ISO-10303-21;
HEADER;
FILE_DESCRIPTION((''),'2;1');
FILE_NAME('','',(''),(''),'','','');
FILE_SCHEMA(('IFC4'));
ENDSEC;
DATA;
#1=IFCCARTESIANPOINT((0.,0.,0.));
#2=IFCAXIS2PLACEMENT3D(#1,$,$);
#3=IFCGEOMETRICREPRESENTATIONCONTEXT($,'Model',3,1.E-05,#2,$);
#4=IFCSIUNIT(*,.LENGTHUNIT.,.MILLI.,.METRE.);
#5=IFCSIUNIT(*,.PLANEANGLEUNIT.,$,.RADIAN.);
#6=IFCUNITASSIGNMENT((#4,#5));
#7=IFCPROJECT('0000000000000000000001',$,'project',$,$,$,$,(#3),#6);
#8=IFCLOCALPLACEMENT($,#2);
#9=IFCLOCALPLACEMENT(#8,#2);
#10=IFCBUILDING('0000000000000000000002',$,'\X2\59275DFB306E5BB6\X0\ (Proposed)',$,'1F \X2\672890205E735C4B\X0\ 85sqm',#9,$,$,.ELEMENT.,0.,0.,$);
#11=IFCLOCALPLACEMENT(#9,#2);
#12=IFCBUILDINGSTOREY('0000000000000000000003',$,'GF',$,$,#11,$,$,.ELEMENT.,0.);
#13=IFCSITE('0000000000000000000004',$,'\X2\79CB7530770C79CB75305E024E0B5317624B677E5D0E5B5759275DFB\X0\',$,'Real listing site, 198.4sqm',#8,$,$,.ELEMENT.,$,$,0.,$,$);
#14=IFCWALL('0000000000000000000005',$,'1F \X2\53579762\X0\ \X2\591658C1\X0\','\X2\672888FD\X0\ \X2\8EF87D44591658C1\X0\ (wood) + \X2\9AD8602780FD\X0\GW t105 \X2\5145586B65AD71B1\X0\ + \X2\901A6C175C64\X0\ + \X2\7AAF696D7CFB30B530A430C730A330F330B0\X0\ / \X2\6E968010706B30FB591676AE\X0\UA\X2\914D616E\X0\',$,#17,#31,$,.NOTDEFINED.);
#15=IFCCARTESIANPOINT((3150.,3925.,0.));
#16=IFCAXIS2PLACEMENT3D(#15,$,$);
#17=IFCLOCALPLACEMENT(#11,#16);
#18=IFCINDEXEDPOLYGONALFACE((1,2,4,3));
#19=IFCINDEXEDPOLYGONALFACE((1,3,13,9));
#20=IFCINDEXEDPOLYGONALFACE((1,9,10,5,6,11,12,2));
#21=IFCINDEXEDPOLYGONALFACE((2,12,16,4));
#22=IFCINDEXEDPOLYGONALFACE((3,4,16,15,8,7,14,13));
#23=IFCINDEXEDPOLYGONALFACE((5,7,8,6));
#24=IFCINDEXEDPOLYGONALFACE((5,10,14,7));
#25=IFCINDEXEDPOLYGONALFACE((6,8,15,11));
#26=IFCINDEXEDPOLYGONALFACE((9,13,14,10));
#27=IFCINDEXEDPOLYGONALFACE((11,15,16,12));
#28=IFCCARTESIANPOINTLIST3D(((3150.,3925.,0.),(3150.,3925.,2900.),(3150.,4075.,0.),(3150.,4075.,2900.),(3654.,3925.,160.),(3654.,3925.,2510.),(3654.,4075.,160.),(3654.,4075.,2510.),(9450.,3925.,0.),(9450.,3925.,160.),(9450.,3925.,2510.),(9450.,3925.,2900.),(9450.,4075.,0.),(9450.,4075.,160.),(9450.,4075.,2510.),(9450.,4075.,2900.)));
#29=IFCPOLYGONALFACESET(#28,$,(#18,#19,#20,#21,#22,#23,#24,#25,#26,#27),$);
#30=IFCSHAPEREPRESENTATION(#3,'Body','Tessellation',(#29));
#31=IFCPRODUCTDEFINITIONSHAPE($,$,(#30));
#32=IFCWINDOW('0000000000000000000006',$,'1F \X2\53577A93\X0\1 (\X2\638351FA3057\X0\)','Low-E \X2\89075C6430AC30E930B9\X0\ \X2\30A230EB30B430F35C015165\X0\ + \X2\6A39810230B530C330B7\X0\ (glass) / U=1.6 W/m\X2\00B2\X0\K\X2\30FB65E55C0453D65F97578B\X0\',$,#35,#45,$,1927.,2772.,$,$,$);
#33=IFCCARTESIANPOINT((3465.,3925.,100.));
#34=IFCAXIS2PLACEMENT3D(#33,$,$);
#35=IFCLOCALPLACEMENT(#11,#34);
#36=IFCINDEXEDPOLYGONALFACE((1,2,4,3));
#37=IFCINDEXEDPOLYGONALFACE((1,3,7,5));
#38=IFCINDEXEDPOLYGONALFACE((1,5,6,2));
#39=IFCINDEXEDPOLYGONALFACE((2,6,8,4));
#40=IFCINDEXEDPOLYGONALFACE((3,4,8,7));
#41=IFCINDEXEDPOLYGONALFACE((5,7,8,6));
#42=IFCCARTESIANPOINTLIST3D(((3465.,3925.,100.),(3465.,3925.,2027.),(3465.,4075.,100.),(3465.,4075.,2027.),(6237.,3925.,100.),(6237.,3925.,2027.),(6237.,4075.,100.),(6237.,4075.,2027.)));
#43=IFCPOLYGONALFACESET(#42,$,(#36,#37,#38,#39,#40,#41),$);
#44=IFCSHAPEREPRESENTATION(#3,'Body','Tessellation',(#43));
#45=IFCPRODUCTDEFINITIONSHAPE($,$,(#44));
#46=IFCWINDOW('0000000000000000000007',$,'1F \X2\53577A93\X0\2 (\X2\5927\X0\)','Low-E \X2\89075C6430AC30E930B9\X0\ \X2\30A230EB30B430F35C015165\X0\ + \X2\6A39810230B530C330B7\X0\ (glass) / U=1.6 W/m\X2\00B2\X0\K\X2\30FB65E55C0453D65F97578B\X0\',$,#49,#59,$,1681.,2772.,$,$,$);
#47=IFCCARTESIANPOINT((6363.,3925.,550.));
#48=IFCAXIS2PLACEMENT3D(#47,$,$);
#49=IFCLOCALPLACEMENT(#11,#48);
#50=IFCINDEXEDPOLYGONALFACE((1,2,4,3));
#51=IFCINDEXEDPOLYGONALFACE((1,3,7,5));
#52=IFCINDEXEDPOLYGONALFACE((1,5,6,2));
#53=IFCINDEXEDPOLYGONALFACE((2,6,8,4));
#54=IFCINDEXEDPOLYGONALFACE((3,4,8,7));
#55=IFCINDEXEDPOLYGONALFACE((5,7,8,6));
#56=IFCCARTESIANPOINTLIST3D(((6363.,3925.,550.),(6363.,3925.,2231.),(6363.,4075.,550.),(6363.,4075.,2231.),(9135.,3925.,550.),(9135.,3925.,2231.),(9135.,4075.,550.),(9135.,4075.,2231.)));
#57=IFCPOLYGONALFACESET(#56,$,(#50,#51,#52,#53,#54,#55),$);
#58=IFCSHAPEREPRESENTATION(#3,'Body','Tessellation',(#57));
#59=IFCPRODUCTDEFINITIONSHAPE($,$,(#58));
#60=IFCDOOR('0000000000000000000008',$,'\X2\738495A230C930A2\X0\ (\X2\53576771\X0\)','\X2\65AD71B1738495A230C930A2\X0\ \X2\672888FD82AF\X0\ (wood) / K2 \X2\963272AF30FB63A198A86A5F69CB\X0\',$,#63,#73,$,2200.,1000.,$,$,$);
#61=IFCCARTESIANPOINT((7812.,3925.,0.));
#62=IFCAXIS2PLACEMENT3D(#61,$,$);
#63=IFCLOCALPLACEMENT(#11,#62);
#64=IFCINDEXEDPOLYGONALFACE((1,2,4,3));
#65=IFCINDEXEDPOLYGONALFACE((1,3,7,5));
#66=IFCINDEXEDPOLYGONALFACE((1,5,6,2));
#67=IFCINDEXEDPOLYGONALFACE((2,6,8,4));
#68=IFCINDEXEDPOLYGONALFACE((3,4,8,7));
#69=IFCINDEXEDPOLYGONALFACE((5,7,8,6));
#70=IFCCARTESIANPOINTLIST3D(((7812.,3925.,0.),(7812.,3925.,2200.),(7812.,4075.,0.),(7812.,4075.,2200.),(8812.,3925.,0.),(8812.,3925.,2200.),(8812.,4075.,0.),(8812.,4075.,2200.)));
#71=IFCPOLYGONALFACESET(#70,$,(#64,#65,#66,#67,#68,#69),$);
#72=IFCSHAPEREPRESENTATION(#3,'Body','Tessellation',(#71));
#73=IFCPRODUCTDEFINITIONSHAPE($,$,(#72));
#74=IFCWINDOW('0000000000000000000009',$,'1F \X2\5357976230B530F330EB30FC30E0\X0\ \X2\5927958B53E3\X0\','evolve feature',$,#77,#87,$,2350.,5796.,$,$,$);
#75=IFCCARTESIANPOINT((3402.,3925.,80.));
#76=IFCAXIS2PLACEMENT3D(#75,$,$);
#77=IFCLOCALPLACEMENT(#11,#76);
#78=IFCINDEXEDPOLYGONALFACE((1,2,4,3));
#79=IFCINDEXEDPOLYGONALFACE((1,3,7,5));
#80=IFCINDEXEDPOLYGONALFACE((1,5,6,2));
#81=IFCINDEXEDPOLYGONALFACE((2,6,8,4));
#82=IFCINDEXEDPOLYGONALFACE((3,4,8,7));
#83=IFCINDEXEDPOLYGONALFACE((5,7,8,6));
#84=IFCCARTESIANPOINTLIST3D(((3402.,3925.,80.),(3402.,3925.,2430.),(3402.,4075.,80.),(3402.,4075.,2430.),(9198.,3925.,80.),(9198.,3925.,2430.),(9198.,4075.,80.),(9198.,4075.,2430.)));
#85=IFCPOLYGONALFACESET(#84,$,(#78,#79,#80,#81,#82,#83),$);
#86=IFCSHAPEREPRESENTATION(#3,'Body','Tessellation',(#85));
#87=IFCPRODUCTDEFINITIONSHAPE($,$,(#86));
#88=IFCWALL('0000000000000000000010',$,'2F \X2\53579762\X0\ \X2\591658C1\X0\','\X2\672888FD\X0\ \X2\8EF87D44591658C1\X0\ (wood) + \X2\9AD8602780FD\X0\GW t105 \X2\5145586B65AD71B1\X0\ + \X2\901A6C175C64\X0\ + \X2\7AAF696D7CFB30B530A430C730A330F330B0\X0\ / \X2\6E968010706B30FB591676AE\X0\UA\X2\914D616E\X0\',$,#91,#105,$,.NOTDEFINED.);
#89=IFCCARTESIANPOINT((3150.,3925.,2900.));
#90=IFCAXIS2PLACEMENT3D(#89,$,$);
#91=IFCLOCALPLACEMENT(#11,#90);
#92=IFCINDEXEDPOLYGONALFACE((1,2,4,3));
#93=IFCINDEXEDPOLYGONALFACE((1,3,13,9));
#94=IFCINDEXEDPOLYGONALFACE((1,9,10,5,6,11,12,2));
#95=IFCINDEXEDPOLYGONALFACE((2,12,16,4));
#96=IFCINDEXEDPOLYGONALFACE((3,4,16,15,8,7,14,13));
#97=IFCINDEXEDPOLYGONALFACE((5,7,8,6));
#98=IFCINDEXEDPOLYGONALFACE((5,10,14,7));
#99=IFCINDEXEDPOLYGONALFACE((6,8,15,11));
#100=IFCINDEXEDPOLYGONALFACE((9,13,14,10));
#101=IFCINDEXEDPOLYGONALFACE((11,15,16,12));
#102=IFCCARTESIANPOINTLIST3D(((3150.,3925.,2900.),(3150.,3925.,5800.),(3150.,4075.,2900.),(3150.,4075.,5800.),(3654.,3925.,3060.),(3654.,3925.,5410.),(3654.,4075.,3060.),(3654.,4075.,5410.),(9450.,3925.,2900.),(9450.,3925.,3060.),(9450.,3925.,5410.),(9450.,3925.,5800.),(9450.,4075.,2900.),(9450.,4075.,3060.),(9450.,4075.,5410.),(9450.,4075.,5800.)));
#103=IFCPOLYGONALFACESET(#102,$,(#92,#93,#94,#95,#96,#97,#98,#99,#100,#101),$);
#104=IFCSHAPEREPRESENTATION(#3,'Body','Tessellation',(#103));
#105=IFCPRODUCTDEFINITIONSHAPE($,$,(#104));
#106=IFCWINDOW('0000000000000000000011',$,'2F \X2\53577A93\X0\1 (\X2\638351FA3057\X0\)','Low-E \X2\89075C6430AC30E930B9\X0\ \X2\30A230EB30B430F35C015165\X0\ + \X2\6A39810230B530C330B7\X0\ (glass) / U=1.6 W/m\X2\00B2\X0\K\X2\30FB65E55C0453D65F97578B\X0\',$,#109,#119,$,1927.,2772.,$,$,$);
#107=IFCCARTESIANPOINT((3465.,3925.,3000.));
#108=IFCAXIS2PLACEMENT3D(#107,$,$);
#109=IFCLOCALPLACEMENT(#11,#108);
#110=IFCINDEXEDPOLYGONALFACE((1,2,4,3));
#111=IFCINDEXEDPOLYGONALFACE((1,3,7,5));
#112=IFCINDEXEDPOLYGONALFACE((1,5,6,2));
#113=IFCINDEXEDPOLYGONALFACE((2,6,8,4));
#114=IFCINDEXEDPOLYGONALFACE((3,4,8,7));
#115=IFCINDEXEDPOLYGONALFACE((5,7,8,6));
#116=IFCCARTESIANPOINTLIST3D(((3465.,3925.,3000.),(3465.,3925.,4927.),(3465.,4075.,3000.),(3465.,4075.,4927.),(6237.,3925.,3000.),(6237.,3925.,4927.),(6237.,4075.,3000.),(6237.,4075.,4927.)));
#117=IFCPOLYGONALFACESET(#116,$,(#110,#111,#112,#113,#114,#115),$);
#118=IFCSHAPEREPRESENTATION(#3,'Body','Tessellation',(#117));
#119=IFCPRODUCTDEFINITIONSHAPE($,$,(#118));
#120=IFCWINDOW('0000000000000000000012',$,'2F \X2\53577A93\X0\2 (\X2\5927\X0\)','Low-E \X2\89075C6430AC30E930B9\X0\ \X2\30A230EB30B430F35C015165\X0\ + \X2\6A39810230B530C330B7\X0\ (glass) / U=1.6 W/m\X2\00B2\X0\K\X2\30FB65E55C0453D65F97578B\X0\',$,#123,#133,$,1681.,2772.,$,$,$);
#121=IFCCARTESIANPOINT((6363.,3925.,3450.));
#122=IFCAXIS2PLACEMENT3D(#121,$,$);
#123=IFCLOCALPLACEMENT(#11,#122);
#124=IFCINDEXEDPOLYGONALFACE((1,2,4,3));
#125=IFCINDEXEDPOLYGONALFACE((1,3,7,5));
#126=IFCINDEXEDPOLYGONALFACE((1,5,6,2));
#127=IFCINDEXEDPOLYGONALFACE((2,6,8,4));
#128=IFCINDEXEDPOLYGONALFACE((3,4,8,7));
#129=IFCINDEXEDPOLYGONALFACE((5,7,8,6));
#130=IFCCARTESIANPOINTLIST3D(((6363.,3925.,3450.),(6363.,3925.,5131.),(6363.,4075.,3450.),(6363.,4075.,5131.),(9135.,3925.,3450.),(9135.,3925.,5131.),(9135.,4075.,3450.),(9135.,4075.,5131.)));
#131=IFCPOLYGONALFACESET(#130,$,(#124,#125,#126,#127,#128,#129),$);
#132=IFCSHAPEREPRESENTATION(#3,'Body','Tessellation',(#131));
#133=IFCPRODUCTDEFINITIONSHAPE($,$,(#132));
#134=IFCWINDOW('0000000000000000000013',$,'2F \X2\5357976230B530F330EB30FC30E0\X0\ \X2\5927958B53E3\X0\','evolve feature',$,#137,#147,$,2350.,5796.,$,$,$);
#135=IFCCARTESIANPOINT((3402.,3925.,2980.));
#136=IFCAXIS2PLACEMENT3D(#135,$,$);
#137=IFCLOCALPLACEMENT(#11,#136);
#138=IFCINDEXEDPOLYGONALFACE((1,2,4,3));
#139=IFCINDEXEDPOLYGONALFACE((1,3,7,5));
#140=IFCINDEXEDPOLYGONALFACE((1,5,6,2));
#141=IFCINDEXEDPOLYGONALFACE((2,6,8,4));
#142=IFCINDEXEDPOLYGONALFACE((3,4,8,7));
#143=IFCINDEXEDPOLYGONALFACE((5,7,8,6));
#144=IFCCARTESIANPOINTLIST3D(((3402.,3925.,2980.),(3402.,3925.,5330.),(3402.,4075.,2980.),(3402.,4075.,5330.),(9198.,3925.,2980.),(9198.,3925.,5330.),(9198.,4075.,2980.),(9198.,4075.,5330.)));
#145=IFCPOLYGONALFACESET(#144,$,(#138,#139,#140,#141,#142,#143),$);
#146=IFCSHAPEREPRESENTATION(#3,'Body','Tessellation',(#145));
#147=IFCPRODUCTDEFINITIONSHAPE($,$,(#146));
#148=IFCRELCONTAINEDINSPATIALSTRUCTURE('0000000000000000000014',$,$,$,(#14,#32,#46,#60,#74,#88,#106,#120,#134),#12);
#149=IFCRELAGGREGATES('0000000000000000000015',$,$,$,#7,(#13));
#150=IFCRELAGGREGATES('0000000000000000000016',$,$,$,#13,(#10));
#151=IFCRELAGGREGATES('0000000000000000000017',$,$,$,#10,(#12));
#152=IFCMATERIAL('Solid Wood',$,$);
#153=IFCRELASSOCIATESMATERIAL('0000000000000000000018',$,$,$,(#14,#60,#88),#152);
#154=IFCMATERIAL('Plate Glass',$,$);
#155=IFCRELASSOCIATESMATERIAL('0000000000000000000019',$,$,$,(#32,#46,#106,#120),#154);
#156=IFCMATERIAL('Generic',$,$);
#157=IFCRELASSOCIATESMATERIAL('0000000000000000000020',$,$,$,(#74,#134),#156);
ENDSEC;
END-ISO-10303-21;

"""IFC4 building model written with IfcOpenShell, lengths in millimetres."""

from ifc_helpers import new_model, si_unit, frame, frame_2d, origin, place, context, project, spatial, rectangle, extrude, material, element, fill, save


model = new_model("IFC4")

# Units and contexts
model_context = context("Model", 3, precision=1e-05, world=origin())
ifc_project = project(units=[si_unit("LENGTHUNIT", "METRE", prefix="MILLI"), si_unit("PLANEANGLEUNIT", "RADIAN")], contexts=[model_context])

# Site, building, storey
site_placement = place(None, origin())
site = spatial("IfcSite", under=ifc_project, at=site_placement, Name="秋田県秋田市下北手松崎字大巻", ObjectType="Real listing site, 198.4sqm", CompositionType="ELEMENT", RefElevation=0.0)
building_placement = place(site_placement, origin())
building = spatial("IfcBuilding", under=site, at=building_placement, Name="大巻の家 (Proposed)", ObjectType="1F 木造平屋 85sqm", CompositionType="ELEMENT", ElevationOfRefHeight=0.0, ElevationOfTerrain=0.0)
storey_placement = place(building_placement, origin())
storey = spatial("IfcBuildingStorey", under=building, at=storey_placement, Name="GF", CompositionType="ELEMENT", Elevation=0.0)

# Shared definitions
ifc_material_1 = material(Name="Solid Wood")
ifc_material_2 = material(Name="Generic")

# Wall, openings, windows, door
wall_1_placement = place(storey_placement, frame((3150.0, 3925.0, 0.0)))
wall_1 = element("IfcWall", 1, at=wall_1_placement, inside=storey, material=ifc_material_1, Name="1F 南面 外壁", Description="木製 軸組外壁 (wood) + 高性能GW t105 充填断熱 + 通気層 + 窯業系サイディング / 準耐火・外皮UA配慮", PredefinedType="NOTDEFINED", context=model_context, shape_type="SweptSolid", body=[
    extrude(rectangle(XDim=6300.0, YDim=150.0, at=frame_2d((3150.0, 75.0))), frame((3150.0, 3925.0, 0.0)), (0.0, 0.0, 1.0), 2900.0),
])
opening_1_placement = place(storey_placement, frame((3465.0, 3925.0, 100.0)))
opening_1 = element("IfcOpeningElement", 2, at=opening_1_placement, cuts=wall_1, PredefinedType="NOTDEFINED", context=model_context, shape_type="SweptSolid", body=[
    extrude(rectangle(XDim=2772.0, YDim=150.0, at=frame_2d((1386.0, 75.0))), frame((3465.0, 3925.0, 100.0)), (0.0, 0.0, 1.0), 1927.0),
])
opening_2_placement = place(storey_placement, frame((6363.0, 3925.0, 550.0)))
opening_2 = element("IfcOpeningElement", 3, at=opening_2_placement, cuts=wall_1, PredefinedType="NOTDEFINED", context=model_context, shape_type="SweptSolid", body=[
    extrude(rectangle(XDim=2772.0, YDim=150.0, at=frame_2d((1386.0, 75.0))), frame((6363.0, 3925.0, 550.0)), (0.0, 0.0, 1.0), 1681.0),
])
opening_3_placement = place(storey_placement, frame((7812.0, 3925.0, 0.0)))
opening_3 = element("IfcOpeningElement", 4, at=opening_3_placement, cuts=wall_1, PredefinedType="NOTDEFINED", context=model_context, shape_type="SweptSolid", body=[
    extrude(rectangle(XDim=1000.0, YDim=150.0, at=frame_2d((500.0, 75.0))), frame((7812.0, 3925.0, 0.0)), (0.0, 0.0, 1.0), 2200.0),
])
opening_4_placement = place(storey_placement, frame((3402.0, 3925.0, 80.0)))
opening_4 = element("IfcOpeningElement", 5, at=opening_4_placement, cuts=wall_1, PredefinedType="NOTDEFINED", context=model_context, shape_type="SweptSolid", body=[
    extrude(rectangle(XDim=5796.0, YDim=150.0, at=frame_2d((2898.0, 75.0))), frame((3402.0, 3925.0, 80.0)), (0.0, 0.0, 1.0), 2350.0),
])
ifc_material_3 = material(Name="Plate Glass")
window_1_placement = place(storey_placement, frame((3465.0, 3925.0, 100.0)))
window_1 = element("IfcWindow", 6, at=window_1_placement, inside=storey, material=ifc_material_3, Name="1F 南窓1 (掃出し)", Description="Low-E 複層ガラス アルゴン封入 + 樹脂サッシ (glass) / U=1.6 W/m²K・日射取得型", OverallHeight=1927.0, OverallWidth=2772.0, context=model_context, shape_type="SweptSolid", body=[
    extrude(rectangle(XDim=2772.0, YDim=150.0, at=frame_2d((1386.0, 75.0))), frame((3465.0, 3925.0, 100.0)), (0.0, 0.0, 1.0), 1927.0),
])
fill(opening_1, window_1)
window_2_placement = place(storey_placement, frame((6363.0, 3925.0, 550.0)))
window_2 = element("IfcWindow", 7, at=window_2_placement, inside=storey, material=ifc_material_3, Name="1F 南窓2 (大)", Description="Low-E 複層ガラス アルゴン封入 + 樹脂サッシ (glass) / U=1.6 W/m²K・日射取得型", OverallHeight=1681.0, OverallWidth=2772.0, context=model_context, shape_type="SweptSolid", body=[
    extrude(rectangle(XDim=2772.0, YDim=150.0, at=frame_2d((1386.0, 75.0))), frame((6363.0, 3925.0, 550.0)), (0.0, 0.0, 1.0), 1681.0),
])
fill(opening_2, window_2)
door_placement = place(storey_placement, frame((7812.0, 3925.0, 0.0)))
door = element("IfcDoor", 8, at=door_placement, inside=storey, material=ifc_material_1, Name="玄関ドア (南東)", Description="断熱玄関ドア 木製芯 (wood) / K2 防犯・採風機構", OverallHeight=2200.0, OverallWidth=1000.0, context=model_context, shape_type="SweptSolid", body=[
    extrude(rectangle(XDim=1000.0, YDim=150.0, at=frame_2d((500.0, 75.0))), frame((7812.0, 3925.0, 0.0)), (0.0, 0.0, 1.0), 2200.0),
])
fill(opening_3, door)
window_3_placement = place(storey_placement, frame((3402.0, 3925.0, 80.0)))
window_3 = element("IfcWindow", 9, at=window_3_placement, inside=storey, material=ifc_material_2, Name="1F 南面サンルーム 大開口", Description="evolve feature", OverallHeight=2350.0, OverallWidth=5796.0, context=model_context, shape_type="SweptSolid", body=[
    extrude(rectangle(XDim=5796.0, YDim=150.0, at=frame_2d((2898.0, 75.0))), frame((3402.0, 3925.0, 80.0)), (0.0, 0.0, 1.0), 2350.0),
])
fill(opening_4, window_3)

# Wall, openings, windows
wall_2_placement = place(storey_placement, frame((3150.0, 3925.0, 2900.0)))
wall_2 = element("IfcWall", 10, at=wall_2_placement, inside=storey, material=ifc_material_1, Name="2F 南面 外壁", Description="木製 軸組外壁 (wood) + 高性能GW t105 充填断熱 + 通気層 + 窯業系サイディング / 準耐火・外皮UA配慮", PredefinedType="NOTDEFINED", context=model_context, shape_type="SweptSolid", body=[
    extrude(rectangle(XDim=6300.0, YDim=150.0, at=frame_2d((3150.0, 75.0))), frame((3150.0, 3925.0, 2900.0)), (0.0, 0.0, 1.0), 2900.0),
])
opening_5_placement = place(storey_placement, frame((3465.0, 3925.0, 3000.0)))
opening_5 = element("IfcOpeningElement", 11, at=opening_5_placement, cuts=wall_2, PredefinedType="NOTDEFINED", context=model_context, shape_type="SweptSolid", body=[
    extrude(rectangle(XDim=2772.0, YDim=150.0, at=frame_2d((1386.0, 75.0))), frame((3465.0, 3925.0, 3000.0)), (0.0, 0.0, 1.0), 1927.0),
])
opening_6_placement = place(storey_placement, frame((6363.0, 3925.0, 3450.0)))
opening_6 = element("IfcOpeningElement", 12, at=opening_6_placement, cuts=wall_2, PredefinedType="NOTDEFINED", context=model_context, shape_type="SweptSolid", body=[
    extrude(rectangle(XDim=2772.0, YDim=150.0, at=frame_2d((1386.0, 75.0))), frame((6363.0, 3925.0, 3450.0)), (0.0, 0.0, 1.0), 1681.0),
])
opening_7_placement = place(storey_placement, frame((3402.0, 3925.0, 2980.0)))
opening_7 = element("IfcOpeningElement", 13, at=opening_7_placement, cuts=wall_2, PredefinedType="NOTDEFINED", context=model_context, shape_type="SweptSolid", body=[
    extrude(rectangle(XDim=5796.0, YDim=150.0, at=frame_2d((2898.0, 75.0))), frame((3402.0, 3925.0, 2980.0)), (0.0, 0.0, 1.0), 2350.0),
])
window_4_placement = place(storey_placement, frame((3465.0, 3925.0, 3000.0)))
window_4 = element("IfcWindow", 14, at=window_4_placement, inside=storey, material=ifc_material_3, Name="2F 南窓1 (掃出し)", Description="Low-E 複層ガラス アルゴン封入 + 樹脂サッシ (glass) / U=1.6 W/m²K・日射取得型", OverallHeight=1927.0, OverallWidth=2772.0, context=model_context, shape_type="SweptSolid", body=[
    extrude(rectangle(XDim=2772.0, YDim=150.0, at=frame_2d((1386.0, 75.0))), frame((3465.0, 3925.0, 3000.0)), (0.0, 0.0, 1.0), 1927.0),
])
fill(opening_5, window_4)
window_5_placement = place(storey_placement, frame((6363.0, 3925.0, 3450.0)))
window_5 = element("IfcWindow", 15, at=window_5_placement, inside=storey, material=ifc_material_3, Name="2F 南窓2 (大)", Description="Low-E 複層ガラス アルゴン封入 + 樹脂サッシ (glass) / U=1.6 W/m²K・日射取得型", OverallHeight=1681.0, OverallWidth=2772.0, context=model_context, shape_type="SweptSolid", body=[
    extrude(rectangle(XDim=2772.0, YDim=150.0, at=frame_2d((1386.0, 75.0))), frame((6363.0, 3925.0, 3450.0)), (0.0, 0.0, 1.0), 1681.0),
])
fill(opening_6, window_5)
window_6_placement = place(storey_placement, frame((3402.0, 3925.0, 2980.0)))
window_6 = element("IfcWindow", 16, at=window_6_placement, inside=storey, material=ifc_material_2, Name="2F 南面サンルーム 大開口", Description="evolve feature", OverallHeight=2350.0, OverallWidth=5796.0, context=model_context, shape_type="SweptSolid", body=[
    extrude(rectangle(XDim=5796.0, YDim=150.0, at=frame_2d((2898.0, 75.0))), frame((3402.0, 3925.0, 2980.0)), (0.0, 0.0, 1.0), 2350.0),
])
fill(opening_7, window_6)

save(model, "model.ifc")
